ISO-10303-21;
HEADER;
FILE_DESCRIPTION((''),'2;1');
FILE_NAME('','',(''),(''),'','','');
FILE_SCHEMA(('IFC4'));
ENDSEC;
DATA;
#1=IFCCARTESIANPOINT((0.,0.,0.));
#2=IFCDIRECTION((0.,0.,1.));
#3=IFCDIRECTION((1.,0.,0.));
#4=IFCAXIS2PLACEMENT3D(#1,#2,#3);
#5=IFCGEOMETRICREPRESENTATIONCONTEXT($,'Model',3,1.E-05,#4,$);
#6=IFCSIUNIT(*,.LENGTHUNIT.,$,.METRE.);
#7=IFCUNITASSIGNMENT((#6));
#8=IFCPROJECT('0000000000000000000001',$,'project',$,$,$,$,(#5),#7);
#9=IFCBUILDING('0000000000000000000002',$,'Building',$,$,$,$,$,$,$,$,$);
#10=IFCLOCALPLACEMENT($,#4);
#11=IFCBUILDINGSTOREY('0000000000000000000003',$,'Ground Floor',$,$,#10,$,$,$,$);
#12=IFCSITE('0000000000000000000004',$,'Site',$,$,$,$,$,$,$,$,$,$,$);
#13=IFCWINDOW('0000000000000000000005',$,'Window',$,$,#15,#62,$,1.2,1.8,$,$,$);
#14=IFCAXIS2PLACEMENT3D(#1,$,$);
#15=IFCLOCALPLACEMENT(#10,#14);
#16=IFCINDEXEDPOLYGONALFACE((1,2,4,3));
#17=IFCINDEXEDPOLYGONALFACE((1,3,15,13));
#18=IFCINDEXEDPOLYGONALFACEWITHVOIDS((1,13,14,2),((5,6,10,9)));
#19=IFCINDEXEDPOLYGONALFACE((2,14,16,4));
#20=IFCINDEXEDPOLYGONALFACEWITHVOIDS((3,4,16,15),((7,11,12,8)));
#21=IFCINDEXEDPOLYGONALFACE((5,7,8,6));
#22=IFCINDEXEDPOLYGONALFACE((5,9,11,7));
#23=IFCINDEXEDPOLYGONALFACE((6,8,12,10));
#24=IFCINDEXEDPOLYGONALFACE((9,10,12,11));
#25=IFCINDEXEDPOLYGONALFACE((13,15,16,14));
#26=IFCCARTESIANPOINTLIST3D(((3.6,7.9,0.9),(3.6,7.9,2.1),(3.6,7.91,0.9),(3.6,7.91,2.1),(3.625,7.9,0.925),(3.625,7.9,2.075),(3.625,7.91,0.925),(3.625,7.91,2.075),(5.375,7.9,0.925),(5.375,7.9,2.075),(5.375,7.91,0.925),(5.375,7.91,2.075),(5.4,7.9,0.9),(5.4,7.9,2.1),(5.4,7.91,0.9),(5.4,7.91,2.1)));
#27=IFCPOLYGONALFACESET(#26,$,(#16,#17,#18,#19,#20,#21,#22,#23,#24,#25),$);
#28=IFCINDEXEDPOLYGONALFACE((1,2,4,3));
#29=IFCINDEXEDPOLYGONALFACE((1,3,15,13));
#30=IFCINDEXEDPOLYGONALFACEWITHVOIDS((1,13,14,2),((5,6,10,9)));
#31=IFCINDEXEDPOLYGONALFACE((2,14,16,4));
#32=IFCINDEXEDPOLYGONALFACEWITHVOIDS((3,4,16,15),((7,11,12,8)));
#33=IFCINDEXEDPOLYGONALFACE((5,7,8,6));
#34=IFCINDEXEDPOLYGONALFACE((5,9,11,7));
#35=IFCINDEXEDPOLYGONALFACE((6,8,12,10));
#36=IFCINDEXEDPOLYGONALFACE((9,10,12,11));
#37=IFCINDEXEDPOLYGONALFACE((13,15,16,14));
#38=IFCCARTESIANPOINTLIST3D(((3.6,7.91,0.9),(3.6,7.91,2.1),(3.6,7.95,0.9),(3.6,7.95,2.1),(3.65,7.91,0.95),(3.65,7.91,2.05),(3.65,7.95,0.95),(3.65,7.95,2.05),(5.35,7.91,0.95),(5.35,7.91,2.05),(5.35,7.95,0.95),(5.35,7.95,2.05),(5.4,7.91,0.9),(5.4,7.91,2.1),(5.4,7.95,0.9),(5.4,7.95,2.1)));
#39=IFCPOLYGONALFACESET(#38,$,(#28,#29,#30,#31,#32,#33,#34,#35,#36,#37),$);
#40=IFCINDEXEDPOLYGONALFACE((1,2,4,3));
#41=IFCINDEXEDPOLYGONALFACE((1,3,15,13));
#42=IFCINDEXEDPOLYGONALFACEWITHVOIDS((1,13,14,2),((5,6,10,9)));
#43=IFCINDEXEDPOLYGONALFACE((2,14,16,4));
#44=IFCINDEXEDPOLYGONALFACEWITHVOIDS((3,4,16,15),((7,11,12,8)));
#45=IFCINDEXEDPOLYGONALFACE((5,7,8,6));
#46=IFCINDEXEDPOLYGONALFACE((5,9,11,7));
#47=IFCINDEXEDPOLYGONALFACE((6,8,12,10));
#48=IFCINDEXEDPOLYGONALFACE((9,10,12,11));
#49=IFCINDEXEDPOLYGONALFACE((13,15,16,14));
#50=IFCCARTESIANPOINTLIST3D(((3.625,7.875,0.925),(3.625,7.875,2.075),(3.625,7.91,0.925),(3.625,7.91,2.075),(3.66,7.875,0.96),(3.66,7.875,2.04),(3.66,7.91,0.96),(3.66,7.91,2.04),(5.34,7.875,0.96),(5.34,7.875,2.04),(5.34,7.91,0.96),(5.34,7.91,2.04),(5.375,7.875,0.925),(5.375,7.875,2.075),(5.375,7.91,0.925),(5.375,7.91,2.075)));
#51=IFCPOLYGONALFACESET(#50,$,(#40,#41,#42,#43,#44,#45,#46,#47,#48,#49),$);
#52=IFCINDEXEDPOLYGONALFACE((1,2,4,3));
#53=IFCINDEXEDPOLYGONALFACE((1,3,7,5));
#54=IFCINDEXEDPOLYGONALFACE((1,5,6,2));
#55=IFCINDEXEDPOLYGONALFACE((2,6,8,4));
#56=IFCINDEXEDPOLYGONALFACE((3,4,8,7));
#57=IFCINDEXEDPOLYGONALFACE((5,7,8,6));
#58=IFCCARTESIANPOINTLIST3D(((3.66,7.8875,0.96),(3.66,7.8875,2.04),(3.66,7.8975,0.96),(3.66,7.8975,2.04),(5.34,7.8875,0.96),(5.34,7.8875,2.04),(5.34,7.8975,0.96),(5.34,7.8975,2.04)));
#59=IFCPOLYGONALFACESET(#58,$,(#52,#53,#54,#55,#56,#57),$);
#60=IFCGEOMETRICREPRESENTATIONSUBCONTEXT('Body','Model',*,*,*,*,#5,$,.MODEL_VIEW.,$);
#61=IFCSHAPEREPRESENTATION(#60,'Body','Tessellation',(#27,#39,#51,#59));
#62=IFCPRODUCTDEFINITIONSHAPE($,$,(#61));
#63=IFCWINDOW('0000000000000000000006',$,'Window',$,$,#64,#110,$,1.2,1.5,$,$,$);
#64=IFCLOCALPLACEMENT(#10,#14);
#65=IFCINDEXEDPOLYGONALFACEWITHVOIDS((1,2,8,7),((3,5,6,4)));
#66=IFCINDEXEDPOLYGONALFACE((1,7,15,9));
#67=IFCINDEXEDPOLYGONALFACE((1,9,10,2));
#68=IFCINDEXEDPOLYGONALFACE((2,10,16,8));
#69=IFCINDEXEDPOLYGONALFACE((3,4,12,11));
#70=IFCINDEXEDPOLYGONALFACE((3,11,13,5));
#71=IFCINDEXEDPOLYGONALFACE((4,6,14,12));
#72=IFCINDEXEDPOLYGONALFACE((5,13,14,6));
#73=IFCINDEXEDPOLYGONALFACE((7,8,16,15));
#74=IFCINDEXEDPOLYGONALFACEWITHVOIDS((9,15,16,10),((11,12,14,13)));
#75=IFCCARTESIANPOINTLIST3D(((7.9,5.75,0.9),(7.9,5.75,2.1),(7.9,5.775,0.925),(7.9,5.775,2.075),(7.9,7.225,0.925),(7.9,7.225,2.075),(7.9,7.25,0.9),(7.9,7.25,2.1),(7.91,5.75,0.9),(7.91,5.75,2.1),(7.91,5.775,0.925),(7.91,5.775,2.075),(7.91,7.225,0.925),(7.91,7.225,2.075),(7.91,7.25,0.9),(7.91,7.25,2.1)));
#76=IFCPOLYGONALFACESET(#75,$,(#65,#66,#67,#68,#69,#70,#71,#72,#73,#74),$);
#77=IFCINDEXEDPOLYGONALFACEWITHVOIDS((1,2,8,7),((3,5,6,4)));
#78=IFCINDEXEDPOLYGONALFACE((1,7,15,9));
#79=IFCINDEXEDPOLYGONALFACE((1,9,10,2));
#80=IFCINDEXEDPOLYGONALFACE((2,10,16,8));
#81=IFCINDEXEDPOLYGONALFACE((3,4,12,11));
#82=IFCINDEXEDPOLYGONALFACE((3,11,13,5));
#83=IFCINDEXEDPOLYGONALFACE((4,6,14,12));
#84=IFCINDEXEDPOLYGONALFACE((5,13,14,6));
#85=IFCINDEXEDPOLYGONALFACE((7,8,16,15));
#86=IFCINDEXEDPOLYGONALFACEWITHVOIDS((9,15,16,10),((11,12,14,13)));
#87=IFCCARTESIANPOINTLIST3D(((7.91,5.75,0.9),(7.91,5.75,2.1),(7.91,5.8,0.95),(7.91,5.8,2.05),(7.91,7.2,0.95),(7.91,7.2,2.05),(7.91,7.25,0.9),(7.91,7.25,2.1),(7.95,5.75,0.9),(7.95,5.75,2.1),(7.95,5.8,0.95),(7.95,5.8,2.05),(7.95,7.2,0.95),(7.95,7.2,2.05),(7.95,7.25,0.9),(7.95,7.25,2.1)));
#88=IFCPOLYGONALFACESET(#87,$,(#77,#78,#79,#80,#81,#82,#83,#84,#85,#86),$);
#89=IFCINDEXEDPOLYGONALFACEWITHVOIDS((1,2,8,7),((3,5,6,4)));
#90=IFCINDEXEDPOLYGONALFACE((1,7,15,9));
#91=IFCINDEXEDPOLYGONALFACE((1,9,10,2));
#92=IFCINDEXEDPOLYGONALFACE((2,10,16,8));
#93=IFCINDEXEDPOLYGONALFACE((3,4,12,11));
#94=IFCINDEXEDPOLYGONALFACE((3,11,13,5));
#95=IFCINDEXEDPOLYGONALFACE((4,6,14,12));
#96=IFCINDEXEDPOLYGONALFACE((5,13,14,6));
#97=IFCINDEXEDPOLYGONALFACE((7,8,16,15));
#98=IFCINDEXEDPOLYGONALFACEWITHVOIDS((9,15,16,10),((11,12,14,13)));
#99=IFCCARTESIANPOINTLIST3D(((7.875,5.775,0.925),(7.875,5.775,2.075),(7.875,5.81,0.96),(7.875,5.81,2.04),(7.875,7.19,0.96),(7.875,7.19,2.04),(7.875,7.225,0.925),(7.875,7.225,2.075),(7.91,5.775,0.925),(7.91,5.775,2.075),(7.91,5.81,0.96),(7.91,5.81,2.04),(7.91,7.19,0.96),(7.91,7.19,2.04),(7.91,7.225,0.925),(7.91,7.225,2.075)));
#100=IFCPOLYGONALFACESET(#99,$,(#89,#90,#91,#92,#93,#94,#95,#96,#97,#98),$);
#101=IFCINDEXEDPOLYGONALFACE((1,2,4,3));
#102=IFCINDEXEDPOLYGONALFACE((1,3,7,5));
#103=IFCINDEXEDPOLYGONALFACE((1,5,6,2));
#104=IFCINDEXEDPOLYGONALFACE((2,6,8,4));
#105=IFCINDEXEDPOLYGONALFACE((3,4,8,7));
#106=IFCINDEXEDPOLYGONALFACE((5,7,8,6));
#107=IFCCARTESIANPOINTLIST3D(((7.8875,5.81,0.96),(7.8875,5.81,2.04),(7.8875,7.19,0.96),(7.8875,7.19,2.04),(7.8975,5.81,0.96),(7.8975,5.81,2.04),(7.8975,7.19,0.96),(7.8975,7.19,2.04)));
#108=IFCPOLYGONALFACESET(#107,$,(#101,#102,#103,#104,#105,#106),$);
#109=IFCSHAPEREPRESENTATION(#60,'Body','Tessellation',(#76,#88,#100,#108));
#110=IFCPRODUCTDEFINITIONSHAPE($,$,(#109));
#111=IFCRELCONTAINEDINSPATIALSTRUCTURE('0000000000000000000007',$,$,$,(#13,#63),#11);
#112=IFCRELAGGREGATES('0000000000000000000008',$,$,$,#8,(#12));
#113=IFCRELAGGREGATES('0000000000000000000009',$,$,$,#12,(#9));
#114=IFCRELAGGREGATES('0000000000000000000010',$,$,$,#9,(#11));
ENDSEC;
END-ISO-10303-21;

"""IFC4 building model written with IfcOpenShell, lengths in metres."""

from ifc_helpers import new_model, si_unit, frame, origin_with_axes, place, context, subcontext, project, spatial, line, indexed_curve, outline, extrude, element, save


model = new_model("IFC4")

# Units and contexts
model_context = context("Model", 3, precision=1e-05, world=origin_with_axes())
body_context = subcontext(model_context, "Body", "Model", "MODEL_VIEW")
ifc_project = project(units=[si_unit("LENGTHUNIT", "METRE")], contexts=[model_context])

# Site, building, storey
site = spatial("IfcSite", under=ifc_project, Name="Site")
building = spatial("IfcBuilding", under=site, Name="Building")
storey_placement = place(None, origin_with_axes())
storey = spatial("IfcBuildingStorey", under=building, at=storey_placement, Name="Ground Floor")

# Windows
window_1_placement = place(storey_placement, frame((5.4, 8.0, 0.9), z_axis=(0.0, 0.0, 1.0), x_axis=(-1.0, 0.0, 0.0)))
element("IfcWindow", 1, at=window_1_placement, inside=storey, Name="Window", OverallHeight=1.2, OverallWidth=1.8, context=body_context, shape_type="SweptSolid", body=[
    extrude(outline(indexed_curve([(0.0, 0.0), (1.8, 0.0), (1.8, 1.2), (0.0, 1.2)], segments=[line(1, 2, 3, 4, 1)]), holes=[indexed_curve([(0.025, 0.025), (1.775, 0.025), (1.775, 1.175), (0.025, 1.175)], segments=[line(1, 2, 3, 4, 1)])]), frame((0.0, 0.09, 0.0), z_axis=(0.0, -1.0, 0.0), x_axis=(1.0, 0.0, 0.0)), (0.0, 0.0, -1.0), 0.01),
    extrude(outline(indexed_curve([(0.0, 0.0), (1.8, 0.0), (1.8, 1.2), (0.0, 1.2)], segments=[line(1, 2, 3, 4, 1)]), holes=[indexed_curve([(0.05, 0.05), (1.75, 0.05), (1.75, 1.15), (0.05, 1.15)], segments=[line(1, 2, 3, 4, 1)])]), frame((0.0, 0.05, 0.0), z_axis=(0.0, -1.0, 0.0), x_axis=(1.0, 0.0, 0.0)), (0.0, 0.0, -1.0), 0.04),
    extrude(outline(indexed_curve([(0.0, 0.0), (1.75, 0.0), (1.75, 1.15), (0.0, 1.15)], segments=[line(1, 2, 3, 4, 1)]), holes=[indexed_curve([(0.035, 0.035), (1.715, 0.035), (1.715, 1.115), (0.035, 1.115)], segments=[line(1, 2, 3, 4, 1)])]), frame((0.025, 0.09, 0.025), z_axis=(0.0, -1.0, 0.0), x_axis=(1.0, 0.0, 0.0)), (0.0, 0.0, -1.0), 0.035),
    extrude(outline(indexed_curve([(0.035, 0.035), (1.715, 0.035), (1.715, 1.115), (0.035, 1.115)], segments=[line(1, 2, 3, 4, 1)])), frame((0.025, 0.1025, 0.025), z_axis=(0.0, -1.0, 0.0), x_axis=(1.0, 0.0, 0.0)), (0.0, 0.0, -1.0), 0.01),
])
window_2_placement = place(storey_placement, frame((8.0, 5.75, 0.9), z_axis=(0.0, 0.0, 1.0), x_axis=(0.0, 1.0, 0.0)))
element("IfcWindow", 2, at=window_2_placement, inside=storey, Name="Window", OverallHeight=1.2, OverallWidth=1.5, context=body_context, shape_type="SweptSolid", body=[
    extrude(outline(indexed_curve([(0.0, 0.0), (1.5, 0.0), (1.5, 1.2), (0.0, 1.2)], segments=[line(1, 2, 3, 4, 1)]), holes=[indexed_curve([(0.025, 0.025), (1.475, 0.025), (1.475, 1.175), (0.025, 1.175)], segments=[line(1, 2, 3, 4, 1)])]), frame((0.0, 0.09, 0.0), z_axis=(0.0, -1.0, 0.0), x_axis=(1.0, 0.0, 0.0)), (0.0, 0.0, -1.0), 0.01),
    extrude(outline(indexed_curve([(0.0, 0.0), (1.5, 0.0), (1.5, 1.2), (0.0, 1.2)], segments=[line(1, 2, 3, 4, 1)]), holes=[indexed_curve([(0.05, 0.05), (1.45, 0.05), (1.45, 1.15), (0.05, 1.15)], segments=[line(1, 2, 3, 4, 1)])]), frame((0.0, 0.05, 0.0), z_axis=(0.0, -1.0, 0.0), x_axis=(1.0, 0.0, 0.0)), (0.0, 0.0, -1.0), 0.04),
    extrude(outline(indexed_curve([(0.0, 0.0), (1.45, 0.0), (1.45, 1.15), (0.0, 1.15)], segments=[line(1, 2, 3, 4, 1)]), holes=[indexed_curve([(0.035, 0.035), (1.415, 0.035), (1.415, 1.115), (0.035, 1.115)], segments=[line(1, 2, 3, 4, 1)])]), frame((0.025, 0.09, 0.025), z_axis=(0.0, -1.0, 0.0), x_axis=(1.0, 0.0, 0.0)), (0.0, 0.0, -1.0), 0.035),
    extrude(outline(indexed_curve([(0.035, 0.035), (1.415, 0.035), (1.415, 1.115), (0.035, 1.115)], segments=[line(1, 2, 3, 4, 1)])), frame((0.025, 0.1025, 0.025), z_axis=(0.0, -1.0, 0.0), x_axis=(1.0, 0.0, 0.0)), (0.0, 0.0, -1.0), 0.01),
])

save(model, "model.ifc")
